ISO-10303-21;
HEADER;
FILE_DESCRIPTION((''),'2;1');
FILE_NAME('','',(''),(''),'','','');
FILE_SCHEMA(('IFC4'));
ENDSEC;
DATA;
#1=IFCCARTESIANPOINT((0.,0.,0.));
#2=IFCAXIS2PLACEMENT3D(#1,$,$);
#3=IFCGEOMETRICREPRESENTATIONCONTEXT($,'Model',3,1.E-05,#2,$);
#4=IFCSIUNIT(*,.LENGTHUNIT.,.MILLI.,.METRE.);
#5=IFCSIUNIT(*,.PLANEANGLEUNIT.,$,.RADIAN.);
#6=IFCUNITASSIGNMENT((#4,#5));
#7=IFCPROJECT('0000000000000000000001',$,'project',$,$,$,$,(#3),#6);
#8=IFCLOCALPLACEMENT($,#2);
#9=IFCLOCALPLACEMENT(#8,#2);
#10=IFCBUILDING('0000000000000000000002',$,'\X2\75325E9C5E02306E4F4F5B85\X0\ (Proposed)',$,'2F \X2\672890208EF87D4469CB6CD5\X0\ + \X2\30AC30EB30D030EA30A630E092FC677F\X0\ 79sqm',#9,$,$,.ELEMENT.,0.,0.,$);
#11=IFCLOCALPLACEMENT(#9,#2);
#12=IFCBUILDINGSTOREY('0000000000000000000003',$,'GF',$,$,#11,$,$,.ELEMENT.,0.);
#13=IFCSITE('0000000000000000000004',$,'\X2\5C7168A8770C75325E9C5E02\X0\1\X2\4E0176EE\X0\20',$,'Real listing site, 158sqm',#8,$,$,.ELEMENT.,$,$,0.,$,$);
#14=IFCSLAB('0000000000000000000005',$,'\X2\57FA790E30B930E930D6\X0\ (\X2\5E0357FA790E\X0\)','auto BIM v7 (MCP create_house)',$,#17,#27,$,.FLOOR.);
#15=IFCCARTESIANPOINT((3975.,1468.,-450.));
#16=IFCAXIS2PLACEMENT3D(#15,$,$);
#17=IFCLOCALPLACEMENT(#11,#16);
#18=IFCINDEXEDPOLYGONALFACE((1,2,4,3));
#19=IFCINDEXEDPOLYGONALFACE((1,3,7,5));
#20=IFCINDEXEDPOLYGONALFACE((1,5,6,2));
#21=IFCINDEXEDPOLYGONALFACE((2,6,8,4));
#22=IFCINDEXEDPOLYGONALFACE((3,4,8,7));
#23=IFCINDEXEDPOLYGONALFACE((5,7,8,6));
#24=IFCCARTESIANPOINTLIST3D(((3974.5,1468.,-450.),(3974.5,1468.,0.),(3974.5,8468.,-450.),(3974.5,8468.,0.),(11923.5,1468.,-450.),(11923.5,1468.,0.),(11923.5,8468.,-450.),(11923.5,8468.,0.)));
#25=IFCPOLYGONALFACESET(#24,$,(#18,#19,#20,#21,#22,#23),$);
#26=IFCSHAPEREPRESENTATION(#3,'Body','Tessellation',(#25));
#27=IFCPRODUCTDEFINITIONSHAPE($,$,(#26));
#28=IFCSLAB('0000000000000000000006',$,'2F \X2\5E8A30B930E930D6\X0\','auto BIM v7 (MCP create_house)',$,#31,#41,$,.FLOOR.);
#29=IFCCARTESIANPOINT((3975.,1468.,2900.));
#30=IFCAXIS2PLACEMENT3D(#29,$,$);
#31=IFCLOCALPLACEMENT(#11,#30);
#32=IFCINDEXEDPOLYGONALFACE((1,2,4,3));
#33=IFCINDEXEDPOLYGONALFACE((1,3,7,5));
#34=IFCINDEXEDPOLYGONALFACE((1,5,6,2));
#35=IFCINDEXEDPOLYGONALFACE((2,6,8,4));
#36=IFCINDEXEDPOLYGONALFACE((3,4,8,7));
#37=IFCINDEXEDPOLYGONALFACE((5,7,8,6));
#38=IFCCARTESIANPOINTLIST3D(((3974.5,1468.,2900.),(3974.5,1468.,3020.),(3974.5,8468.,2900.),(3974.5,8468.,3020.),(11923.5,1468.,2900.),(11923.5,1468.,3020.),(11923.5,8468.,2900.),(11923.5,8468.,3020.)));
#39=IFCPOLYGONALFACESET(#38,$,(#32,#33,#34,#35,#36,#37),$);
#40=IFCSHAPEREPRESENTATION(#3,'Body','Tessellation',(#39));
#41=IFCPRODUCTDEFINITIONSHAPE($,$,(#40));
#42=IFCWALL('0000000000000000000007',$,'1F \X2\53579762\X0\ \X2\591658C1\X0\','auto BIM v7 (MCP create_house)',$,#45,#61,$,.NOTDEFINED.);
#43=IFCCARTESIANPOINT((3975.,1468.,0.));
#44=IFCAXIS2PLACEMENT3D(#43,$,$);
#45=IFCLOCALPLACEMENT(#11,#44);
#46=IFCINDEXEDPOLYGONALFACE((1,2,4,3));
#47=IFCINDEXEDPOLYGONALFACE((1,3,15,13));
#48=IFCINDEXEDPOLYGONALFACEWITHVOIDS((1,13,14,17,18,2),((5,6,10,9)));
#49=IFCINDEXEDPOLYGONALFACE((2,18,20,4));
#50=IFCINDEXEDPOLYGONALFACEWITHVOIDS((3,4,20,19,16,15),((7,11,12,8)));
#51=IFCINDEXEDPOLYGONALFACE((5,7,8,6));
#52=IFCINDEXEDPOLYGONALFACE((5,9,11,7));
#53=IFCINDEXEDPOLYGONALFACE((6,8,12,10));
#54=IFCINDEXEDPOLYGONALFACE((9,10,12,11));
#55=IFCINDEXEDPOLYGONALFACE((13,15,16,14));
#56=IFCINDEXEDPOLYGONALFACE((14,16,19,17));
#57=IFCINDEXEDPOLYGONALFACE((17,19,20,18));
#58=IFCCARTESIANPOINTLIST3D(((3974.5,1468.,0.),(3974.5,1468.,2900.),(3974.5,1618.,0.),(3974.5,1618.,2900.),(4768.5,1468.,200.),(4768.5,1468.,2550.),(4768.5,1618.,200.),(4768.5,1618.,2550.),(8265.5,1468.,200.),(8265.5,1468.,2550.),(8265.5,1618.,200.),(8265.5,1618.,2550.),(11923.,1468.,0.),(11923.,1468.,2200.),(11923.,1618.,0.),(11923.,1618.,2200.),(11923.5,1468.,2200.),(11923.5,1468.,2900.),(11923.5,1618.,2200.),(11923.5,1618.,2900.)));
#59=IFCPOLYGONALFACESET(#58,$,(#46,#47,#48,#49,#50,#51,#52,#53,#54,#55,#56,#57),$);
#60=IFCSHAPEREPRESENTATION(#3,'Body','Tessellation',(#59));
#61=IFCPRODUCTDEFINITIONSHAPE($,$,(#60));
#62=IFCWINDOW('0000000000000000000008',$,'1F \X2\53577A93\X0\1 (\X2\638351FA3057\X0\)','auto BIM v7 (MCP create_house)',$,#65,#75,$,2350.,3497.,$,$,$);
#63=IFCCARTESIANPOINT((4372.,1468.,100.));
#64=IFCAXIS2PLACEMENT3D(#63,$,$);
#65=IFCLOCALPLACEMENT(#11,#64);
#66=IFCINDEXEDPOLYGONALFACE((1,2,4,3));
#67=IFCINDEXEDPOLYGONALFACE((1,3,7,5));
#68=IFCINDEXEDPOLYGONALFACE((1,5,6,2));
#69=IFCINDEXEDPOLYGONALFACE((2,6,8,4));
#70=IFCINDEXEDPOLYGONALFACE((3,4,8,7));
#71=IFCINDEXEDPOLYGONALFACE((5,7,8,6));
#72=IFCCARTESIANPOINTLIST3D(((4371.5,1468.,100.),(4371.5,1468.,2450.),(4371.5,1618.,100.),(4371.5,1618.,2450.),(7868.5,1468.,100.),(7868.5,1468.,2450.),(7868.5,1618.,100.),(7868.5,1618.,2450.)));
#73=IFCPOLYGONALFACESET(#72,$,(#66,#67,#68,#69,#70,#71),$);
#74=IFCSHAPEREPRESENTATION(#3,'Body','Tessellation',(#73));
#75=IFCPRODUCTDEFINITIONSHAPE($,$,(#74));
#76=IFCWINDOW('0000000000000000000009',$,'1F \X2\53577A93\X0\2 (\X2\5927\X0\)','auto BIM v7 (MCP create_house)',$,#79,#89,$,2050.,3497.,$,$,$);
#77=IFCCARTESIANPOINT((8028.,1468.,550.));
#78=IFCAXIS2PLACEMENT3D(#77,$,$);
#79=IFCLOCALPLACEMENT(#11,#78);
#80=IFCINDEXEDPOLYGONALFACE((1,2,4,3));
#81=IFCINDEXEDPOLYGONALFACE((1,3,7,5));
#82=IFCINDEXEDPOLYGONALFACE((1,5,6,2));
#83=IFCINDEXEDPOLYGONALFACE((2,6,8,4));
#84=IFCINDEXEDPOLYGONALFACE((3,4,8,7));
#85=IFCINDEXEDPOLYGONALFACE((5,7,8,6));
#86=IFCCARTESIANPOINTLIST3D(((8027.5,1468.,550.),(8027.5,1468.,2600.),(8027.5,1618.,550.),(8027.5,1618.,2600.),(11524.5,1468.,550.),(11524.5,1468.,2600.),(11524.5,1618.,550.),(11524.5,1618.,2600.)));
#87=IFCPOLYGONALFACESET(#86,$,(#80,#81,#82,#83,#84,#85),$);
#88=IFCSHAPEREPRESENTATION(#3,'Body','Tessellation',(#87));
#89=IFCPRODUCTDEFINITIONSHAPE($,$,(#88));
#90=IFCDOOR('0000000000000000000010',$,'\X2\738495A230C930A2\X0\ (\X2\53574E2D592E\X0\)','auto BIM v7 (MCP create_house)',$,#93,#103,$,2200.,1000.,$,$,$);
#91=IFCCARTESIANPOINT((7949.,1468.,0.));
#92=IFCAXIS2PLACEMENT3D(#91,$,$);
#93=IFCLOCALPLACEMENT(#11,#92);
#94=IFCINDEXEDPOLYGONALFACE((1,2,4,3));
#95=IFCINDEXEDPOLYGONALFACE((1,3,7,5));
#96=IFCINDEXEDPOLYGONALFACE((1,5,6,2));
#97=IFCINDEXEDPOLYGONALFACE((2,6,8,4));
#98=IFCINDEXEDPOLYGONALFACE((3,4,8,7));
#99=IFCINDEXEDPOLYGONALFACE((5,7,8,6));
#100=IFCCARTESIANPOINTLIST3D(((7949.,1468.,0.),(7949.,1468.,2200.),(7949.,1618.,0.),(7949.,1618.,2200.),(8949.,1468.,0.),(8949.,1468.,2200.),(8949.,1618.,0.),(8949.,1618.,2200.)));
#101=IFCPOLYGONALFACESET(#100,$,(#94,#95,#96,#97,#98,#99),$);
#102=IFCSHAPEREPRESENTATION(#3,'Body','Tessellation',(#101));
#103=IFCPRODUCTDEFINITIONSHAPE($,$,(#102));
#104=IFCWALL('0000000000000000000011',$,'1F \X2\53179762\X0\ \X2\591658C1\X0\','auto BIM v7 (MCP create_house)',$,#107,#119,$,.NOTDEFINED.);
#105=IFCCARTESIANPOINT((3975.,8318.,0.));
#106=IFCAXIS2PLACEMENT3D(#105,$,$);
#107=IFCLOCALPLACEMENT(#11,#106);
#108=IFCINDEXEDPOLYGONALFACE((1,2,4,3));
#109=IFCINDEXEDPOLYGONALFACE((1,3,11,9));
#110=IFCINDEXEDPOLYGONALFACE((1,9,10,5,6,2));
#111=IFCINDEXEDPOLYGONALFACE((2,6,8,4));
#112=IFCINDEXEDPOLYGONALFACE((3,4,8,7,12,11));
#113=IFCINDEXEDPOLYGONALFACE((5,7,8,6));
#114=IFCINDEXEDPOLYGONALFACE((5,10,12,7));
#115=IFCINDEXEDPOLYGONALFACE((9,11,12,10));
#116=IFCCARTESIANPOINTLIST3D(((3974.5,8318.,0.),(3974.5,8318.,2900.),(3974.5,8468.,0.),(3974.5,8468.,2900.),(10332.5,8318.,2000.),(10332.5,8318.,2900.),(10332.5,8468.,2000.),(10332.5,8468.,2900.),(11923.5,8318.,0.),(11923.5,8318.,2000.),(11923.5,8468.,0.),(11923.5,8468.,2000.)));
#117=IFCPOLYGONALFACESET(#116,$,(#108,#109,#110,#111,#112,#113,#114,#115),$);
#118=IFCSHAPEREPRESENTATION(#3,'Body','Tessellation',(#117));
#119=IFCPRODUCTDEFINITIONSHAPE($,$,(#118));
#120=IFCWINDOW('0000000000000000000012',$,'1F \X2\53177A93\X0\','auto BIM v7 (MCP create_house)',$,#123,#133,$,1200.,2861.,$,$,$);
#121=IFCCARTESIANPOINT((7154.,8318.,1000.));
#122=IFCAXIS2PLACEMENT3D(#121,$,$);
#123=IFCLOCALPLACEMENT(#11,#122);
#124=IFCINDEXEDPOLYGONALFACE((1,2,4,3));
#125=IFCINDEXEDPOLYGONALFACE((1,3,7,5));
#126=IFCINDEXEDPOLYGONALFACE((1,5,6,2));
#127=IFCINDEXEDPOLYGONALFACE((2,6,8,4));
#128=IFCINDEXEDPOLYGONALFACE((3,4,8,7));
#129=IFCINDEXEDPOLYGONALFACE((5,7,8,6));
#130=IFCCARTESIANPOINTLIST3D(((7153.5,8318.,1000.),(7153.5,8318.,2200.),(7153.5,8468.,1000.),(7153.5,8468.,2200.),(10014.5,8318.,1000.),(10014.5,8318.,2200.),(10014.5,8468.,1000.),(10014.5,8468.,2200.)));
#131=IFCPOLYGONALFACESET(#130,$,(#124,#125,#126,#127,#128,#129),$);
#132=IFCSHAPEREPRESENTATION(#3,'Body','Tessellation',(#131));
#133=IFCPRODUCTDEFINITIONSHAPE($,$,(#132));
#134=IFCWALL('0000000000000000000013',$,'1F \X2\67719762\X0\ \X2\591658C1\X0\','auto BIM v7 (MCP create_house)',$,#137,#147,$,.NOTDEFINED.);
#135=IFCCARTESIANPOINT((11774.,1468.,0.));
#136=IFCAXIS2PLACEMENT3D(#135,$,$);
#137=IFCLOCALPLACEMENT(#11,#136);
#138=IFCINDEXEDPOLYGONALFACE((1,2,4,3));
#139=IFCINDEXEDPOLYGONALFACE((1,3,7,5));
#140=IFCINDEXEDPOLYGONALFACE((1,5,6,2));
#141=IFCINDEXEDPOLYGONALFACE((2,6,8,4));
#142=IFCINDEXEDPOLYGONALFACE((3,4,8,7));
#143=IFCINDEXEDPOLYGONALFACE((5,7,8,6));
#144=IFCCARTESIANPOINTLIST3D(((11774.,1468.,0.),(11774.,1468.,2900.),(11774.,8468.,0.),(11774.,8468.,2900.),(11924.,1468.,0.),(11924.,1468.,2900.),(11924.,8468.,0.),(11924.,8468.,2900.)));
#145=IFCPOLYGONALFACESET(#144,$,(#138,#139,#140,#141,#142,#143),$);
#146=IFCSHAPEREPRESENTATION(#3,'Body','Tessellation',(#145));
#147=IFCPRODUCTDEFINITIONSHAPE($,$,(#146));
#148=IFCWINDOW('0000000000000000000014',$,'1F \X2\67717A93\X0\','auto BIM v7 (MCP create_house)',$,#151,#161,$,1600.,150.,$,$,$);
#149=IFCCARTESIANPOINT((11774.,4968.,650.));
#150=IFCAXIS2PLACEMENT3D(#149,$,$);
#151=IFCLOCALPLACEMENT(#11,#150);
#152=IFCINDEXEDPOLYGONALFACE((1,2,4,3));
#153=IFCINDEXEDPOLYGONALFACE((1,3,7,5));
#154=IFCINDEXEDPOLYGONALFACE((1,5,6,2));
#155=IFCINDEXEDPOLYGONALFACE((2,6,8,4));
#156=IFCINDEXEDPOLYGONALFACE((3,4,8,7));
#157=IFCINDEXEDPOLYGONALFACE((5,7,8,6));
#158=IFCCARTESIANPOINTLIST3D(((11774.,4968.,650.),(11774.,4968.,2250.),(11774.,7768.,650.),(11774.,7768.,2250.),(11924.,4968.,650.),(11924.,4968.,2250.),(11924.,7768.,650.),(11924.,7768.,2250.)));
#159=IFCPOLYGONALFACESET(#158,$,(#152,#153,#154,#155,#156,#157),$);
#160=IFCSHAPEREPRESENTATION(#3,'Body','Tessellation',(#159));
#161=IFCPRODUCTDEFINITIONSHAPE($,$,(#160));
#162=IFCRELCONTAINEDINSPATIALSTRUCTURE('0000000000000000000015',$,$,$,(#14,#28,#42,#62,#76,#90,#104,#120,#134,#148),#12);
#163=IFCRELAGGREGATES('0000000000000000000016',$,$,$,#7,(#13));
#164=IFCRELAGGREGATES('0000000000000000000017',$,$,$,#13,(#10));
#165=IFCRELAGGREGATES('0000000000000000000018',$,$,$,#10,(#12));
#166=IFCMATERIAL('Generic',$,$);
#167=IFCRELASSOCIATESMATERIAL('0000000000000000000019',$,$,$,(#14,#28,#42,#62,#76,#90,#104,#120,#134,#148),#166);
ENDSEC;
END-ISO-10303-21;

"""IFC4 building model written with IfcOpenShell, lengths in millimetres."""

from ifc_helpers import new_model, si_unit, frame, frame_2d, origin, place, context, project, spatial, rectangle, extrude, material, element, fill, save


model = new_model("IFC4")

# Units and contexts
model_context = context("Model", 3, precision=1e-05, world=origin())
ifc_project = project(units=[si_unit("LENGTHUNIT", "METRE", prefix="MILLI"), si_unit("PLANEANGLEUNIT", "RADIAN")], contexts=[model_context])

# Site, building, storey
site_placement = place(None, origin())
site = spatial("IfcSite", under=ifc_project, at=site_placement, Name="山梨県甲府市1丁目20", ObjectType="Real listing site, 158sqm", CompositionType="ELEMENT", RefElevation=0.0)
building_placement = place(site_placement, origin())
building = spatial("IfcBuilding", under=site, at=building_placement, Name="甲府市の住宅 (Proposed)", ObjectType="2F 木造軸組構法 + ガルバリウム鋼板 79sqm", CompositionType="ELEMENT", ElevationOfRefHeight=0.0, ElevationOfTerrain=0.0)
storey_placement = place(building_placement, origin())
storey = spatial("IfcBuildingStorey", under=building, at=storey_placement, Name="GF", CompositionType="ELEMENT", Elevation=0.0)

# Slabs
ifc_material = material(Name="Generic")
slab_1_placement = place(storey_placement, frame((3975.0, 1468.0, -450.0)))
element("IfcSlab", 1, at=slab_1_placement, inside=storey, material=ifc_material, Name="基礎スラブ (布基礎)", Description="auto BIM v7 (MCP create_house)", PredefinedType="FLOOR", context=model_context, shape_type="SweptSolid", body=[
    extrude(rectangle(XDim=7949.0, YDim=7000.0, at=frame_2d((3974.0, 3500.0))), frame((3975.0, 1468.0, -450.0)), (0.0, 0.0, 1.0), 450.0),
])
slab_2_placement = place(storey_placement, frame((3975.0, 1468.0, 2900.0)))
element("IfcSlab", 2, at=slab_2_placement, inside=storey, material=ifc_material, Name="2F 床スラブ", Description="auto BIM v7 (MCP create_house)", PredefinedType="FLOOR", context=model_context, shape_type="SweptSolid", body=[
    extrude(rectangle(XDim=7949.0, YDim=7000.0, at=frame_2d((3974.0, 3500.0))), frame((3975.0, 1468.0, 2900.0)), (0.0, 0.0, 1.0), 120.0),
])

# Wall, openings, windows, door
wall_1_placement = place(storey_placement, frame((3975.0, 1468.0, 0.0)))
wall_1 = element("IfcWall", 3, at=wall_1_placement, inside=storey, material=ifc_material, Name="1F 南面 外壁", Description="auto BIM v7 (MCP create_house)", PredefinedType="NOTDEFINED", context=model_context, shape_type="SweptSolid", body=[
    extrude(rectangle(XDim=7949.0, YDim=150.0, at=frame_2d((3974.0, 75.0))), frame((3975.0, 1468.0, 0.0)), (0.0, 0.0, 1.0), 2900.0),
])
opening_1_placement = place(storey_placement, frame((4372.0, 1468.0, 100.0)))
opening_1 = element("IfcOpeningElement", 4, at=opening_1_placement, cuts=wall_1, PredefinedType="NOTDEFINED", context=model_context, shape_type="SweptSolid", body=[
    extrude(rectangle(XDim=3497.0, YDim=150.0, at=frame_2d((1748.0, 75.0))), frame((4372.0, 1468.0, 100.0)), (0.0, 0.0, 1.0), 2350.0),
])
opening_2_placement = place(storey_placement, frame((8028.0, 1468.0, 550.0)))
opening_2 = element("IfcOpeningElement", 5, at=opening_2_placement, cuts=wall_1, PredefinedType="NOTDEFINED", context=model_context, shape_type="SweptSolid", body=[
    extrude(rectangle(XDim=3497.0, YDim=150.0, at=frame_2d((1748.0, 75.0))), frame((8028.0, 1468.0, 550.0)), (0.0, 0.0, 1.0), 2050.0),
])
opening_3_placement = place(storey_placement, frame((7949.0, 1468.0, 0.0)))
opening_3 = element("IfcOpeningElement", 6, at=opening_3_placement, cuts=wall_1, PredefinedType="NOTDEFINED", context=model_context, shape_type="SweptSolid", body=[
    extrude(rectangle(XDim=1000.0, YDim=150.0, at=frame_2d((500.0, 75.0))), frame((7949.0, 1468.0, 0.0)), (0.0, 0.0, 1.0), 2200.0),
])
window_1_placement = place(storey_placement, frame((4372.0, 1468.0, 100.0)))
window_1 = element("IfcWindow", 7, at=window_1_placement, inside=storey, material=ifc_material, Name="1F 南窓1 (掃出し)", Description="auto BIM v7 (MCP create_house)", OverallHeight=2350.0, OverallWidth=3497.0, context=model_context, shape_type="SweptSolid", body=[
    extrude(rectangle(XDim=3497.0, YDim=150.0, at=frame_2d((1748.0, 75.0))), frame((4372.0, 1468.0, 100.0)), (0.0, 0.0, 1.0), 2350.0),
])
fill(opening_1, window_1)
window_2_placement = place(storey_placement, frame((8028.0, 1468.0, 550.0)))
window_2 = element("IfcWindow", 8, at=window_2_placement, inside=storey, material=ifc_material, Name="1F 南窓2 (大)", Description="auto BIM v7 (MCP create_house)", OverallHeight=2050.0, OverallWidth=3497.0, context=model_context, shape_type="SweptSolid", body=[
    extrude(rectangle(XDim=3497.0, YDim=150.0, at=frame_2d((1748.0, 75.0))), frame((8028.0, 1468.0, 550.0)), (0.0, 0.0, 1.0), 2050.0),
])
fill(opening_2, window_2)
door_placement = place(storey_placement, frame((7949.0, 1468.0, 0.0)))
door = element("IfcDoor", 9, at=door_placement, inside=storey, material=ifc_material, Name="玄関ドア (南中央)", Description="auto BIM v7 (MCP create_house)", OverallHeight=2200.0, OverallWidth=1000.0, context=model_context, shape_type="SweptSolid", body=[
    extrude(rectangle(XDim=1000.0, YDim=150.0, at=frame_2d((500.0, 75.0))), frame((7949.0, 1468.0, 0.0)), (0.0, 0.0, 1.0), 2200.0),
])
fill(opening_3, door)

# Walls, openings, windows
wall_2_placement = place(storey_placement, frame((3975.0, 8318.0, 0.0)))
wall_2 = element("IfcWall", 10, at=wall_2_placement, inside=storey, material=ifc_material, Name="1F 北面 外壁", Description="auto BIM v7 (MCP create_house)", PredefinedType="NOTDEFINED", context=model_context, shape_type="SweptSolid", body=[
    extrude(rectangle(XDim=7949.0, YDim=150.0, at=frame_2d((3974.0, 75.0))), frame((3975.0, 8318.0, 0.0)), (0.0, 0.0, 1.0), 2900.0),
])
opening_4_placement = place(storey_placement, frame((7154.0, 8318.0, 1000.0)))
opening_4 = element("IfcOpeningElement", 11, at=opening_4_placement, cuts=wall_2, PredefinedType="NOTDEFINED", context=model_context, shape_type="SweptSolid", body=[
    extrude(rectangle(XDim=2861.0, YDim=150.0, at=frame_2d((1430.0, 75.0))), frame((7154.0, 8318.0, 1000.0)), (0.0, 0.0, 1.0), 1200.0),
])
window_3_placement = place(storey_placement, frame((7154.0, 8318.0, 1000.0)))
window_3 = element("IfcWindow", 12, at=window_3_placement, inside=storey, material=ifc_material, Name="1F 北窓", Description="auto BIM v7 (MCP create_house)", OverallHeight=1200.0, OverallWidth=2861.0, context=model_context, shape_type="SweptSolid", body=[
    extrude(rectangle(XDim=2861.0, YDim=150.0, at=frame_2d((1430.0, 75.0))), frame((7154.0, 8318.0, 1000.0)), (0.0, 0.0, 1.0), 1200.0),
])
fill(opening_4, window_3)
wall_3_placement = place(storey_placement, frame((11774.0, 1468.0, 0.0)))
wall_3 = element("IfcWall", 13, at=wall_3_placement, inside=storey, material=ifc_material, Name="1F 東面 外壁", Description="auto BIM v7 (MCP create_house)", PredefinedType="NOTDEFINED", context=model_context, shape_type="SweptSolid", body=[
    extrude(rectangle(XDim=150.0, YDim=7000.0, at=frame_2d((75.0, 3500.0))), frame((11774.0, 1468.0, 0.0)), (0.0, 0.0, 1.0), 2900.0),
])
opening_5_placement = place(storey_placement, frame((11774.0, 4968.0, 650.0)))
opening_5 = element("IfcOpeningElement", 14, at=opening_5_placement, cuts=wall_3, PredefinedType="NOTDEFINED", context=model_context, shape_type="SweptSolid", body=[
    extrude(rectangle(XDim=150.0, YDim=2800.0, at=frame_2d((75.0, 1400.0))), frame((11774.0, 4968.0, 650.0)), (0.0, 0.0, 1.0), 1600.0),
])
window_4_placement = place(storey_placement, frame((11774.0, 4968.0, 650.0)))
window_4 = element("IfcWindow", 15, at=window_4_placement, inside=storey, material=ifc_material, Name="1F 東窓", Description="auto BIM v7 (MCP create_house)", OverallHeight=1600.0, OverallWidth=150.0, context=model_context, shape_type="SweptSolid", body=[
    extrude(rectangle(XDim=150.0, YDim=2800.0, at=frame_2d((75.0, 1400.0))), frame((11774.0, 4968.0, 650.0)), (0.0, 0.0, 1.0), 1600.0),
])
fill(opening_5, window_4)

save(model, "model.ifc")
